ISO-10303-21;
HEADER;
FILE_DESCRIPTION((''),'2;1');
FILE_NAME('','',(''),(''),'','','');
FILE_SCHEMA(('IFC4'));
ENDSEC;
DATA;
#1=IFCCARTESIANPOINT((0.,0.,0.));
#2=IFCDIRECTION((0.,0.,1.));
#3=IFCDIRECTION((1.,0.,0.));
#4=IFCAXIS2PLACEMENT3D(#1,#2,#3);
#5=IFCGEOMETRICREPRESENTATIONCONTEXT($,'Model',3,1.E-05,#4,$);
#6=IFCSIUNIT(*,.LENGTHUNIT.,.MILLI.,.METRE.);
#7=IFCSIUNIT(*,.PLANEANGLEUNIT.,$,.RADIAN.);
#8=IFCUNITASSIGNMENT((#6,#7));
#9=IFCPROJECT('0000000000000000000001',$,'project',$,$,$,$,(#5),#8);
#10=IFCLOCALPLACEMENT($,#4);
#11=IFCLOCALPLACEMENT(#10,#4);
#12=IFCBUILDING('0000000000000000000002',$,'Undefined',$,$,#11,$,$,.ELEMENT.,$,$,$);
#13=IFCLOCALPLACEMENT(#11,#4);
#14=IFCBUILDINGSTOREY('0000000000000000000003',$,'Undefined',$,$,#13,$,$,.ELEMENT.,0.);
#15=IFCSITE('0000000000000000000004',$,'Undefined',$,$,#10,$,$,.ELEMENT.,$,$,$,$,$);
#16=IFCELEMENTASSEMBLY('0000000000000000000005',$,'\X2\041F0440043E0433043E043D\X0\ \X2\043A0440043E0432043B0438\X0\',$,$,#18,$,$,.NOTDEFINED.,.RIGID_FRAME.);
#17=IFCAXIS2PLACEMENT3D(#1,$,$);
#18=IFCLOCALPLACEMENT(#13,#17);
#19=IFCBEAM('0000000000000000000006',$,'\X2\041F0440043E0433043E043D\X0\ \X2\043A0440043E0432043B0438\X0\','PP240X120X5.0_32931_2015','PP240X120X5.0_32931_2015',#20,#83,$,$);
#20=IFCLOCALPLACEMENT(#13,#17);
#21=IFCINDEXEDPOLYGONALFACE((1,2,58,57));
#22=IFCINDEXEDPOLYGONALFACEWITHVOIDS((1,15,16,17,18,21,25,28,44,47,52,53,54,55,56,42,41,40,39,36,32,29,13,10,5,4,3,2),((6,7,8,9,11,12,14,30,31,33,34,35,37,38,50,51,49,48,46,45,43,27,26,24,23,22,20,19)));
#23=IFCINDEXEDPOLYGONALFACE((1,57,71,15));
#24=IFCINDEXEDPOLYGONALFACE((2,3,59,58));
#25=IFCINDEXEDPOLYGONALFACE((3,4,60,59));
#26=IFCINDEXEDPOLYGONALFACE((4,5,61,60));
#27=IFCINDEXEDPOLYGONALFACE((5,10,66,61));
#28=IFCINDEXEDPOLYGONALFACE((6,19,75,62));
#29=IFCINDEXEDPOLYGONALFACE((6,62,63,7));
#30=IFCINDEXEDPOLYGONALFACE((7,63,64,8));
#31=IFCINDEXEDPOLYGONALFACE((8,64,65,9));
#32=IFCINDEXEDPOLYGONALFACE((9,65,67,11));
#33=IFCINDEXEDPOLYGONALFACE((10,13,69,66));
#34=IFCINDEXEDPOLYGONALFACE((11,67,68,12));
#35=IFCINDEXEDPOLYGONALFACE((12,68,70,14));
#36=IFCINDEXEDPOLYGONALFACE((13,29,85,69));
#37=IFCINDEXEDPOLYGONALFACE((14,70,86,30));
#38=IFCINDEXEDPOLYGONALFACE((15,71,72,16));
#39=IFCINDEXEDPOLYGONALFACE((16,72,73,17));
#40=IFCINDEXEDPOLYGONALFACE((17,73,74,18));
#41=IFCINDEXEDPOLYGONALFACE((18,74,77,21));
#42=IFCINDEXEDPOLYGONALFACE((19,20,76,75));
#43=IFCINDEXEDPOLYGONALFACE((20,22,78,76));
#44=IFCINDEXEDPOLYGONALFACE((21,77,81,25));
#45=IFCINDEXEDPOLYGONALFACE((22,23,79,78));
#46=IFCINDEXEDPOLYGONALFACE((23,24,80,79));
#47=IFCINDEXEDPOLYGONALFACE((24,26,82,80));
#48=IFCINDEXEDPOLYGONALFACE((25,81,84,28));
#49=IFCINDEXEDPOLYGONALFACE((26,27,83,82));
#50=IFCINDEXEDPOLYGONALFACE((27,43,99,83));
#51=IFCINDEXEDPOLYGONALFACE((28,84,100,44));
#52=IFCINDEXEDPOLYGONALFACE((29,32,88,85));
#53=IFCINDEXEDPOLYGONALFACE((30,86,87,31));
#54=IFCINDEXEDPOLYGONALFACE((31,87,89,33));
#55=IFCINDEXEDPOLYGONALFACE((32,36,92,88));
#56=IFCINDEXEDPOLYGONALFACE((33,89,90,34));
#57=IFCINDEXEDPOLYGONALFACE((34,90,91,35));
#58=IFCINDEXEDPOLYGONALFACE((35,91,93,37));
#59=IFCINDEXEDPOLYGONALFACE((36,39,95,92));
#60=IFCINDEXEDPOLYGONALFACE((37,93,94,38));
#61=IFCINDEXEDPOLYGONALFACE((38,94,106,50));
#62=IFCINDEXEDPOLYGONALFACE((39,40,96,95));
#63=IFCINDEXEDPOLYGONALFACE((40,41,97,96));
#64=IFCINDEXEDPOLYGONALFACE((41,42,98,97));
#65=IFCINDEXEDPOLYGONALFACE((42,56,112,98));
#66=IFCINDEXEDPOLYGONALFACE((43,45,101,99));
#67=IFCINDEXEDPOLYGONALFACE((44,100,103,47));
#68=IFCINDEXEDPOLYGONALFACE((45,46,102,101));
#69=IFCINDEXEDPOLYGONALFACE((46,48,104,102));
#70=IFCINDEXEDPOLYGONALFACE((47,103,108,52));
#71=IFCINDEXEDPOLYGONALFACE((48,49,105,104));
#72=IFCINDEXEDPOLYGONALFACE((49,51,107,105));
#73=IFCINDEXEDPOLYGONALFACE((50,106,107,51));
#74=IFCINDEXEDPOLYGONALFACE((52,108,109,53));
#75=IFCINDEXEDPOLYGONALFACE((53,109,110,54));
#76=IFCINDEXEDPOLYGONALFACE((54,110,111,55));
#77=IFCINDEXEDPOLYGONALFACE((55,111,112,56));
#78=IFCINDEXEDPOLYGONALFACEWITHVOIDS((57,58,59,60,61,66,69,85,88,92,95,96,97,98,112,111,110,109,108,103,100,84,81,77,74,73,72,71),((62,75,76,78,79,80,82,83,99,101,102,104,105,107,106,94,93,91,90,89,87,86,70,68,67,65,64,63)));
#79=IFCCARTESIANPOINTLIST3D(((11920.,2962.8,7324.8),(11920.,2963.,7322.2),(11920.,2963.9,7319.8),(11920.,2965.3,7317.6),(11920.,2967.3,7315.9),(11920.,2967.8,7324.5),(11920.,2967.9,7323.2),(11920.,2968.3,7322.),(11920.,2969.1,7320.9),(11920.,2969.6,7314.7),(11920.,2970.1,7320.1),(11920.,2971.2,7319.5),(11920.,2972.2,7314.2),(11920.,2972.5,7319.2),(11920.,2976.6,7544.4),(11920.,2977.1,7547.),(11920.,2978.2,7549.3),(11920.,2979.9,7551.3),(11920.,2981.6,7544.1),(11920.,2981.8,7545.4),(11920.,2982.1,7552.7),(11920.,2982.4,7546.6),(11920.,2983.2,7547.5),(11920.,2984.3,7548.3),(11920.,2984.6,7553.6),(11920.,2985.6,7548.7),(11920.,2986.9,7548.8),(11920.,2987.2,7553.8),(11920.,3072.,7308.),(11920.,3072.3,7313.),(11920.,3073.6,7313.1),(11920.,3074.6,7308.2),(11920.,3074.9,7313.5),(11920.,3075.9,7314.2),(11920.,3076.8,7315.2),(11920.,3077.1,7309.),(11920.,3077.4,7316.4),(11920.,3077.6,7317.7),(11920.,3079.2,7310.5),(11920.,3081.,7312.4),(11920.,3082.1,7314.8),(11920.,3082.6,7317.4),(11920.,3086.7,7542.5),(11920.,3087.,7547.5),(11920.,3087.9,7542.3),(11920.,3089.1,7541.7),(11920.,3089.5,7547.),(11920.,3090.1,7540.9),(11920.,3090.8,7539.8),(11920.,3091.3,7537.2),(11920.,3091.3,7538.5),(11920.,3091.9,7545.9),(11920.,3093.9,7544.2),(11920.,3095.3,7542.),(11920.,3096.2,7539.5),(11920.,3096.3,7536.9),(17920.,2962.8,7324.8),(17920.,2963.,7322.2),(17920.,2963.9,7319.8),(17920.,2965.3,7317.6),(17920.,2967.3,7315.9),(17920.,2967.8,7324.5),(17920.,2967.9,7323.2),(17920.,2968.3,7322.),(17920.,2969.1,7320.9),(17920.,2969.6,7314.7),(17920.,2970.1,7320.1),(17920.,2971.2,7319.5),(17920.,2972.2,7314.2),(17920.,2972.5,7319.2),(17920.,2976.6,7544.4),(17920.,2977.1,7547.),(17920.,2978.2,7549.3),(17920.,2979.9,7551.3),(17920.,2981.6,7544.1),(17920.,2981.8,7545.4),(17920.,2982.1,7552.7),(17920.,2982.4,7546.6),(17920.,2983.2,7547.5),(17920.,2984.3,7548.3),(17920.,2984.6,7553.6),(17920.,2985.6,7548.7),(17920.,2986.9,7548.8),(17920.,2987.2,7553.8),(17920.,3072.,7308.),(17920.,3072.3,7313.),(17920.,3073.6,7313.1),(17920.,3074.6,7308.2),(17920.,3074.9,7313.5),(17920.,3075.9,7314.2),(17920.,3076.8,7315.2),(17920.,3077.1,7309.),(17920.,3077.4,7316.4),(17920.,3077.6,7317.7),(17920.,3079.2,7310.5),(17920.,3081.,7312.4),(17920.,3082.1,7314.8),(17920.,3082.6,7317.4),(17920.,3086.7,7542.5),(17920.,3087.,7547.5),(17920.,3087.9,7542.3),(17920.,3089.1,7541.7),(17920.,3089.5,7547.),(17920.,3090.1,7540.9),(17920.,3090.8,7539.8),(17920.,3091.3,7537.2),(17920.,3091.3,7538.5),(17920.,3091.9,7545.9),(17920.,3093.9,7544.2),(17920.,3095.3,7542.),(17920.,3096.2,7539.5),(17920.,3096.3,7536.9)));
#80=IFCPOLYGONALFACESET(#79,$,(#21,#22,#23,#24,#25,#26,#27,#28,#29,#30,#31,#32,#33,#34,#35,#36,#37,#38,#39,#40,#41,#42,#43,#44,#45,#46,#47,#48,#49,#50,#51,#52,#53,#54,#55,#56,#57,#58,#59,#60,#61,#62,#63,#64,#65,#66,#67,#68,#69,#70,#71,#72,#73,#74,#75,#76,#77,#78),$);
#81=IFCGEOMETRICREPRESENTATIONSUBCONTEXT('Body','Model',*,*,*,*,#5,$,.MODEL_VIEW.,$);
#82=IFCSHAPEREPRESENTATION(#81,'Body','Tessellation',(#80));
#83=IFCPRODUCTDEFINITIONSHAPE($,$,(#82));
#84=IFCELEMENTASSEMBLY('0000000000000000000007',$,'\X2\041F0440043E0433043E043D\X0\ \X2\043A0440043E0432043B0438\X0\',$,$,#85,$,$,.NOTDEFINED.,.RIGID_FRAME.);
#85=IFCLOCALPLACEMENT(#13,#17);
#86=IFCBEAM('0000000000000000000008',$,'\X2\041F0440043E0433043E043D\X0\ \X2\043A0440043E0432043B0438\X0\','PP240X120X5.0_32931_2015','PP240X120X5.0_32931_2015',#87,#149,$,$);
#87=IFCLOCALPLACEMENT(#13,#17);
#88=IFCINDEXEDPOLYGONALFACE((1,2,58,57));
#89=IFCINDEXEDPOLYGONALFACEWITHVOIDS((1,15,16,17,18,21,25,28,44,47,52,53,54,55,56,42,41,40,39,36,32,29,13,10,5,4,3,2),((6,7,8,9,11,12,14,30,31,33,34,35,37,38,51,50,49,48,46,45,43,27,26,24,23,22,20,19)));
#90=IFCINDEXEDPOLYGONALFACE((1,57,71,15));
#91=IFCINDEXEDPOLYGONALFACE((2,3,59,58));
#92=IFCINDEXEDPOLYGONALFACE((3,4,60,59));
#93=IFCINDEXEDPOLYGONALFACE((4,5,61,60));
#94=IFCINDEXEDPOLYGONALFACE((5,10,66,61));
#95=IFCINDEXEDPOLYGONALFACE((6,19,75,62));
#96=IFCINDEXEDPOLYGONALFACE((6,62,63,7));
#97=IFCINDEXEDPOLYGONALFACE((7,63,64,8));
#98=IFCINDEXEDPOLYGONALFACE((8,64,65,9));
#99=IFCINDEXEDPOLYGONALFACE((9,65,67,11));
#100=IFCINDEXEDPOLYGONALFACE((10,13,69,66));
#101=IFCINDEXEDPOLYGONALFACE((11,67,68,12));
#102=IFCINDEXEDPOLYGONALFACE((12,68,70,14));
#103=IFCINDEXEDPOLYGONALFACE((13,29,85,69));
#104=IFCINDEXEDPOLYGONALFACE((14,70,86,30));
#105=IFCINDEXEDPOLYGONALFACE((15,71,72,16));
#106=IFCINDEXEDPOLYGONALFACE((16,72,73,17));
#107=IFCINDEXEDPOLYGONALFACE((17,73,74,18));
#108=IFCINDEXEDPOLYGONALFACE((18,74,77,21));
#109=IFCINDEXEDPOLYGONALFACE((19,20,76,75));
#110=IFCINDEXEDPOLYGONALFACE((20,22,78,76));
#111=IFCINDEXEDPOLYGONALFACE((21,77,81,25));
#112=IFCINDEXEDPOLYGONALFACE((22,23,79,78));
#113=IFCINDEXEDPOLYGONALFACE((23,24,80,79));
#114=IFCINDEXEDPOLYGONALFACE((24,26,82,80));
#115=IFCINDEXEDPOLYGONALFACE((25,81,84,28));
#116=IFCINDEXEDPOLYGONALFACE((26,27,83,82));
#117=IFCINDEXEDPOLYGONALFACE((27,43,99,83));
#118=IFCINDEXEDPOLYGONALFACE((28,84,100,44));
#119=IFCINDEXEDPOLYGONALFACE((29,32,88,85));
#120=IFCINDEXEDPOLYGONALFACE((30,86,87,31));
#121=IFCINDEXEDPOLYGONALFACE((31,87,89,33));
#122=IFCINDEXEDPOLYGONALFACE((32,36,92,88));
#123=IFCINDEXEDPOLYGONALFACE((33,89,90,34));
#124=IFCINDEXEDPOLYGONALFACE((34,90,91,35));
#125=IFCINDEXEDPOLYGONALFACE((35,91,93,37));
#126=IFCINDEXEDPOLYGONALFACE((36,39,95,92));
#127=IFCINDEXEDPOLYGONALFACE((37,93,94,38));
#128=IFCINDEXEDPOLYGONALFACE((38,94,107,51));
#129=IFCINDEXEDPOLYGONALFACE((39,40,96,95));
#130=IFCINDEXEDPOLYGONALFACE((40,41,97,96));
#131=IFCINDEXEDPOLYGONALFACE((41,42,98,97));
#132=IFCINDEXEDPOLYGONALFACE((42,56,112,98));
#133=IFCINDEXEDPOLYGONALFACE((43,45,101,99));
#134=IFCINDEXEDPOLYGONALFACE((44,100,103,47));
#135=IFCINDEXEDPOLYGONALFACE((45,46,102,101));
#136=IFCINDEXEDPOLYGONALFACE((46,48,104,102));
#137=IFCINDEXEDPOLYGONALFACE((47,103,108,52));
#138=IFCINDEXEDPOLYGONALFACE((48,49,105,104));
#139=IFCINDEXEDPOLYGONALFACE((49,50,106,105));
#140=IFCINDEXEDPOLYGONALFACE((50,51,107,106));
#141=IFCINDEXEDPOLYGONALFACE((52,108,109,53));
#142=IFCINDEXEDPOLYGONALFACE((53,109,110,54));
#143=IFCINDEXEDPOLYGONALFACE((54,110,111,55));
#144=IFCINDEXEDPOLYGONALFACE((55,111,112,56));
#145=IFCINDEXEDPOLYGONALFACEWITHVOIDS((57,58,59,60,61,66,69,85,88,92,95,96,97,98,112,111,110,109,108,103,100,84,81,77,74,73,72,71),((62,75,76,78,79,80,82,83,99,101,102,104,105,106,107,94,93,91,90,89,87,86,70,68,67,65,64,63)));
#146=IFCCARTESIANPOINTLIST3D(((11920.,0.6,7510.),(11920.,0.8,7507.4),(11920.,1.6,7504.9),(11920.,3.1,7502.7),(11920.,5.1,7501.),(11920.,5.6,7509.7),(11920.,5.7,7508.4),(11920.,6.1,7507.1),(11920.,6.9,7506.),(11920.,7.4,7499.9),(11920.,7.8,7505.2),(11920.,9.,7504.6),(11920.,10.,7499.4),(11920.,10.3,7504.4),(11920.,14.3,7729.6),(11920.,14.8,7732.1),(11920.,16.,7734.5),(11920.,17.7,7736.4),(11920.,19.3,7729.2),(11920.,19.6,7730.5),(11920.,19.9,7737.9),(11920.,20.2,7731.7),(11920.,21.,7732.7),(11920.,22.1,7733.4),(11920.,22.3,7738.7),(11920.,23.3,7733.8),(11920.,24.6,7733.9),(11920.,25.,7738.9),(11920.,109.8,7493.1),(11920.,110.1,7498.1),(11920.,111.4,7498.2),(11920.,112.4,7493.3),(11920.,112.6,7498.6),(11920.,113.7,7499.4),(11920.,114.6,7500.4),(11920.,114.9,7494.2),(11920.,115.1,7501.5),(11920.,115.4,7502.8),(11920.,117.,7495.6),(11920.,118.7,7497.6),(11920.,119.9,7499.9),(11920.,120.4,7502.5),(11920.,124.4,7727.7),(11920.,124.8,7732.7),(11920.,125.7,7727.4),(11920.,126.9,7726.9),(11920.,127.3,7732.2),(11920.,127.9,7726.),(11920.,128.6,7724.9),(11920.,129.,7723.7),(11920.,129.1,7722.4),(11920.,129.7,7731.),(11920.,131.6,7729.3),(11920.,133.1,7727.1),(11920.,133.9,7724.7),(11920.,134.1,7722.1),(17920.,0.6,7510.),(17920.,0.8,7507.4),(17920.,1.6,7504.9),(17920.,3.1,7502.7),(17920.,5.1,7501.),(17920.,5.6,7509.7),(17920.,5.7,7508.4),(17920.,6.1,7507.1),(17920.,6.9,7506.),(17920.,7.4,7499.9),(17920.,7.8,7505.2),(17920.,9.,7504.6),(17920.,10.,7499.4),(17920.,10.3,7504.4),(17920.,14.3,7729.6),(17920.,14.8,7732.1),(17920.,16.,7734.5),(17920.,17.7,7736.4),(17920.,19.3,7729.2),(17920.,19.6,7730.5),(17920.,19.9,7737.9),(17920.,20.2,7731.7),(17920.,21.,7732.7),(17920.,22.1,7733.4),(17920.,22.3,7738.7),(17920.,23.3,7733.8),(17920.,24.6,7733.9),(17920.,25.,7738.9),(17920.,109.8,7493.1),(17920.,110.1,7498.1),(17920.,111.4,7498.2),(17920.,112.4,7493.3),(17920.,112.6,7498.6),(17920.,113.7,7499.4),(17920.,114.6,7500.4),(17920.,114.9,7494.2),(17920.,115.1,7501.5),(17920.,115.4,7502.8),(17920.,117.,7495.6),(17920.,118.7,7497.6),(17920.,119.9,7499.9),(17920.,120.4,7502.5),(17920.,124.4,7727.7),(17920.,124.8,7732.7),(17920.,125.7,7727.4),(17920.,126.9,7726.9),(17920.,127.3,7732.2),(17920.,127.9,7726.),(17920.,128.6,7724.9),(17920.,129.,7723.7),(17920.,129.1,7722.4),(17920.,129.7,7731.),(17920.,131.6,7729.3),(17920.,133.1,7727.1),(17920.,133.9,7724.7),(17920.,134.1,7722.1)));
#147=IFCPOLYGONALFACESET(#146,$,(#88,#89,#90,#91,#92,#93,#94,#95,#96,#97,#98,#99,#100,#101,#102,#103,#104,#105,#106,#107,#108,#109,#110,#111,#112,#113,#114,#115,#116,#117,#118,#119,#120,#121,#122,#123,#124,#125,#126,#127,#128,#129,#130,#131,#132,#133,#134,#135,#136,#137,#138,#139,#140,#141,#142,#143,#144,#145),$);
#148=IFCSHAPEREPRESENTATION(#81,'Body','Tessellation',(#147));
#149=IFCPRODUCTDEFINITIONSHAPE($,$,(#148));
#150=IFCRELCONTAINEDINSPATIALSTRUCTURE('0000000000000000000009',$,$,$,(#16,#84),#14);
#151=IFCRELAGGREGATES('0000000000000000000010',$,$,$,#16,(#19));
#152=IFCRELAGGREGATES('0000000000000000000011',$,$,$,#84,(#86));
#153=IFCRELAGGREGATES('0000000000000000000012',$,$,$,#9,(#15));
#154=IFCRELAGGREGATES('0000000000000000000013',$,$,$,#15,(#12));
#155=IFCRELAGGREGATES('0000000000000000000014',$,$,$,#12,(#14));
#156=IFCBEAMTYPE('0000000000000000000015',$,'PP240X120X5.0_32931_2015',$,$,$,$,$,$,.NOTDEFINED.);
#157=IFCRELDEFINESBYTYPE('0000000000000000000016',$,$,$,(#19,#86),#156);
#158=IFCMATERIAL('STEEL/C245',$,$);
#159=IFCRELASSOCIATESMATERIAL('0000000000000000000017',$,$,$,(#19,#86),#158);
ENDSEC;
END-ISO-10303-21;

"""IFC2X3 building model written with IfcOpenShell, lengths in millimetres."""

from ifc_helpers import new_model, si_unit, frame, origin_with_axes, origin_2d_with_axis, place, context, subcontext, project, spatial, hollow_rectangle, extrude, material, type_object, element, aggregate, save


model = new_model("IFC2X3")

# Units and contexts
model_context = context("Model", 3, precision=1e-05, world=origin_with_axes())
body_context = subcontext(model_context, "Body", "Model", "MODEL_VIEW")
ifc_project = project(units=[si_unit("LENGTHUNIT", "METRE", prefix="MILLI"), si_unit("PLANEANGLEUNIT", "RADIAN")], contexts=[model_context])

# Site, building, storey
site_placement = place(None, origin_with_axes())
site = spatial("IfcSite", under=ifc_project, at=site_placement, Name="Undefined", CompositionType="ELEMENT")
building_placement = place(site_placement, origin_with_axes())
building = spatial("IfcBuilding", under=site, at=building_placement, Name="Undefined", CompositionType="ELEMENT")
storey_placement = place(building_placement, origin_with_axes())
storey = spatial("IfcBuildingStorey", under=building, at=storey_placement, Name="Undefined", CompositionType="ELEMENT", Elevation=0.0)

# Shared definitions
ifc_material = material(Name="STEEL/C245")

# Element assemblies, beams
assembly_1_placement = place(storey_placement, origin_with_axes())
assembly_1 = element("IfcElementAssembly", 1, at=assembly_1_placement, inside=storey, Name="Прогон кровли", AssemblyPlace="NOTDEFINED", PredefinedType="RIGID_FRAME")
beam_type_1 = type_object("IfcBeamType", Name="PP240X120X5.0_32931_2015", PredefinedType="NOTDEFINED")
beam_1_placement = place(assembly_1_placement, frame((17920.0, 3029.6, 7430.9), z_axis=(0.0, 0.062378, 0.998053), x_axis=(-1.0, 0.0, 0.0)))
beam_1 = element("IfcBeam", 2, at=beam_1_placement, type_object=beam_type_1, material=ifc_material, Name="Прогон кровли", Description="PP240X120X5.0_32931_2015", ObjectType="PP240X120X5.0_32931_2015", context=body_context, shape_type="SweptSolid", body=[
    extrude(hollow_rectangle(XDim=120.0, YDim=240.0, WallThickness=5.0, InnerFilletRadius=5.0, OuterFilletRadius=10.0, at=origin_2d_with_axis()), frame((6000.0, 0.0, 0.0), z_axis=(-1.0, 0.0, 0.0), x_axis=(0.0, -1.0, 0.0)), (0.0, 0.0, 1.0), 6000.0),
])
aggregate(assembly_1, [beam_1])
assembly_2_placement = place(storey_placement, origin_with_axes())
assembly_2 = element("IfcElementAssembly", 3, at=assembly_2_placement, inside=storey, Name="Прогон кровли", AssemblyPlace="NOTDEFINED", PredefinedType="RIGID_FRAME")
beam_2_placement = place(assembly_2_placement, frame((17920.0, 67.4, 7616.0), z_axis=(0.0, 0.062378, 0.998053), x_axis=(-1.0, 0.0, 0.0)))
beam_2 = element("IfcBeam", 4, at=beam_2_placement, type_object=beam_type_1, material=ifc_material, Name="Прогон кровли", Description="PP240X120X5.0_32931_2015", ObjectType="PP240X120X5.0_32931_2015", context=body_context, shape_type="SweptSolid", body=[
    extrude(hollow_rectangle(XDim=120.0, YDim=240.0, WallThickness=5.0, InnerFilletRadius=5.0, OuterFilletRadius=10.0, at=origin_2d_with_axis()), frame((6000.0, 0.0, 0.0), z_axis=(-1.0, 0.0, 0.0), x_axis=(0.0, -1.0, 0.0)), (0.0, 0.0, 1.0), 6000.0),
])
aggregate(assembly_2, [beam_2])

save(model, "model.ifc")
